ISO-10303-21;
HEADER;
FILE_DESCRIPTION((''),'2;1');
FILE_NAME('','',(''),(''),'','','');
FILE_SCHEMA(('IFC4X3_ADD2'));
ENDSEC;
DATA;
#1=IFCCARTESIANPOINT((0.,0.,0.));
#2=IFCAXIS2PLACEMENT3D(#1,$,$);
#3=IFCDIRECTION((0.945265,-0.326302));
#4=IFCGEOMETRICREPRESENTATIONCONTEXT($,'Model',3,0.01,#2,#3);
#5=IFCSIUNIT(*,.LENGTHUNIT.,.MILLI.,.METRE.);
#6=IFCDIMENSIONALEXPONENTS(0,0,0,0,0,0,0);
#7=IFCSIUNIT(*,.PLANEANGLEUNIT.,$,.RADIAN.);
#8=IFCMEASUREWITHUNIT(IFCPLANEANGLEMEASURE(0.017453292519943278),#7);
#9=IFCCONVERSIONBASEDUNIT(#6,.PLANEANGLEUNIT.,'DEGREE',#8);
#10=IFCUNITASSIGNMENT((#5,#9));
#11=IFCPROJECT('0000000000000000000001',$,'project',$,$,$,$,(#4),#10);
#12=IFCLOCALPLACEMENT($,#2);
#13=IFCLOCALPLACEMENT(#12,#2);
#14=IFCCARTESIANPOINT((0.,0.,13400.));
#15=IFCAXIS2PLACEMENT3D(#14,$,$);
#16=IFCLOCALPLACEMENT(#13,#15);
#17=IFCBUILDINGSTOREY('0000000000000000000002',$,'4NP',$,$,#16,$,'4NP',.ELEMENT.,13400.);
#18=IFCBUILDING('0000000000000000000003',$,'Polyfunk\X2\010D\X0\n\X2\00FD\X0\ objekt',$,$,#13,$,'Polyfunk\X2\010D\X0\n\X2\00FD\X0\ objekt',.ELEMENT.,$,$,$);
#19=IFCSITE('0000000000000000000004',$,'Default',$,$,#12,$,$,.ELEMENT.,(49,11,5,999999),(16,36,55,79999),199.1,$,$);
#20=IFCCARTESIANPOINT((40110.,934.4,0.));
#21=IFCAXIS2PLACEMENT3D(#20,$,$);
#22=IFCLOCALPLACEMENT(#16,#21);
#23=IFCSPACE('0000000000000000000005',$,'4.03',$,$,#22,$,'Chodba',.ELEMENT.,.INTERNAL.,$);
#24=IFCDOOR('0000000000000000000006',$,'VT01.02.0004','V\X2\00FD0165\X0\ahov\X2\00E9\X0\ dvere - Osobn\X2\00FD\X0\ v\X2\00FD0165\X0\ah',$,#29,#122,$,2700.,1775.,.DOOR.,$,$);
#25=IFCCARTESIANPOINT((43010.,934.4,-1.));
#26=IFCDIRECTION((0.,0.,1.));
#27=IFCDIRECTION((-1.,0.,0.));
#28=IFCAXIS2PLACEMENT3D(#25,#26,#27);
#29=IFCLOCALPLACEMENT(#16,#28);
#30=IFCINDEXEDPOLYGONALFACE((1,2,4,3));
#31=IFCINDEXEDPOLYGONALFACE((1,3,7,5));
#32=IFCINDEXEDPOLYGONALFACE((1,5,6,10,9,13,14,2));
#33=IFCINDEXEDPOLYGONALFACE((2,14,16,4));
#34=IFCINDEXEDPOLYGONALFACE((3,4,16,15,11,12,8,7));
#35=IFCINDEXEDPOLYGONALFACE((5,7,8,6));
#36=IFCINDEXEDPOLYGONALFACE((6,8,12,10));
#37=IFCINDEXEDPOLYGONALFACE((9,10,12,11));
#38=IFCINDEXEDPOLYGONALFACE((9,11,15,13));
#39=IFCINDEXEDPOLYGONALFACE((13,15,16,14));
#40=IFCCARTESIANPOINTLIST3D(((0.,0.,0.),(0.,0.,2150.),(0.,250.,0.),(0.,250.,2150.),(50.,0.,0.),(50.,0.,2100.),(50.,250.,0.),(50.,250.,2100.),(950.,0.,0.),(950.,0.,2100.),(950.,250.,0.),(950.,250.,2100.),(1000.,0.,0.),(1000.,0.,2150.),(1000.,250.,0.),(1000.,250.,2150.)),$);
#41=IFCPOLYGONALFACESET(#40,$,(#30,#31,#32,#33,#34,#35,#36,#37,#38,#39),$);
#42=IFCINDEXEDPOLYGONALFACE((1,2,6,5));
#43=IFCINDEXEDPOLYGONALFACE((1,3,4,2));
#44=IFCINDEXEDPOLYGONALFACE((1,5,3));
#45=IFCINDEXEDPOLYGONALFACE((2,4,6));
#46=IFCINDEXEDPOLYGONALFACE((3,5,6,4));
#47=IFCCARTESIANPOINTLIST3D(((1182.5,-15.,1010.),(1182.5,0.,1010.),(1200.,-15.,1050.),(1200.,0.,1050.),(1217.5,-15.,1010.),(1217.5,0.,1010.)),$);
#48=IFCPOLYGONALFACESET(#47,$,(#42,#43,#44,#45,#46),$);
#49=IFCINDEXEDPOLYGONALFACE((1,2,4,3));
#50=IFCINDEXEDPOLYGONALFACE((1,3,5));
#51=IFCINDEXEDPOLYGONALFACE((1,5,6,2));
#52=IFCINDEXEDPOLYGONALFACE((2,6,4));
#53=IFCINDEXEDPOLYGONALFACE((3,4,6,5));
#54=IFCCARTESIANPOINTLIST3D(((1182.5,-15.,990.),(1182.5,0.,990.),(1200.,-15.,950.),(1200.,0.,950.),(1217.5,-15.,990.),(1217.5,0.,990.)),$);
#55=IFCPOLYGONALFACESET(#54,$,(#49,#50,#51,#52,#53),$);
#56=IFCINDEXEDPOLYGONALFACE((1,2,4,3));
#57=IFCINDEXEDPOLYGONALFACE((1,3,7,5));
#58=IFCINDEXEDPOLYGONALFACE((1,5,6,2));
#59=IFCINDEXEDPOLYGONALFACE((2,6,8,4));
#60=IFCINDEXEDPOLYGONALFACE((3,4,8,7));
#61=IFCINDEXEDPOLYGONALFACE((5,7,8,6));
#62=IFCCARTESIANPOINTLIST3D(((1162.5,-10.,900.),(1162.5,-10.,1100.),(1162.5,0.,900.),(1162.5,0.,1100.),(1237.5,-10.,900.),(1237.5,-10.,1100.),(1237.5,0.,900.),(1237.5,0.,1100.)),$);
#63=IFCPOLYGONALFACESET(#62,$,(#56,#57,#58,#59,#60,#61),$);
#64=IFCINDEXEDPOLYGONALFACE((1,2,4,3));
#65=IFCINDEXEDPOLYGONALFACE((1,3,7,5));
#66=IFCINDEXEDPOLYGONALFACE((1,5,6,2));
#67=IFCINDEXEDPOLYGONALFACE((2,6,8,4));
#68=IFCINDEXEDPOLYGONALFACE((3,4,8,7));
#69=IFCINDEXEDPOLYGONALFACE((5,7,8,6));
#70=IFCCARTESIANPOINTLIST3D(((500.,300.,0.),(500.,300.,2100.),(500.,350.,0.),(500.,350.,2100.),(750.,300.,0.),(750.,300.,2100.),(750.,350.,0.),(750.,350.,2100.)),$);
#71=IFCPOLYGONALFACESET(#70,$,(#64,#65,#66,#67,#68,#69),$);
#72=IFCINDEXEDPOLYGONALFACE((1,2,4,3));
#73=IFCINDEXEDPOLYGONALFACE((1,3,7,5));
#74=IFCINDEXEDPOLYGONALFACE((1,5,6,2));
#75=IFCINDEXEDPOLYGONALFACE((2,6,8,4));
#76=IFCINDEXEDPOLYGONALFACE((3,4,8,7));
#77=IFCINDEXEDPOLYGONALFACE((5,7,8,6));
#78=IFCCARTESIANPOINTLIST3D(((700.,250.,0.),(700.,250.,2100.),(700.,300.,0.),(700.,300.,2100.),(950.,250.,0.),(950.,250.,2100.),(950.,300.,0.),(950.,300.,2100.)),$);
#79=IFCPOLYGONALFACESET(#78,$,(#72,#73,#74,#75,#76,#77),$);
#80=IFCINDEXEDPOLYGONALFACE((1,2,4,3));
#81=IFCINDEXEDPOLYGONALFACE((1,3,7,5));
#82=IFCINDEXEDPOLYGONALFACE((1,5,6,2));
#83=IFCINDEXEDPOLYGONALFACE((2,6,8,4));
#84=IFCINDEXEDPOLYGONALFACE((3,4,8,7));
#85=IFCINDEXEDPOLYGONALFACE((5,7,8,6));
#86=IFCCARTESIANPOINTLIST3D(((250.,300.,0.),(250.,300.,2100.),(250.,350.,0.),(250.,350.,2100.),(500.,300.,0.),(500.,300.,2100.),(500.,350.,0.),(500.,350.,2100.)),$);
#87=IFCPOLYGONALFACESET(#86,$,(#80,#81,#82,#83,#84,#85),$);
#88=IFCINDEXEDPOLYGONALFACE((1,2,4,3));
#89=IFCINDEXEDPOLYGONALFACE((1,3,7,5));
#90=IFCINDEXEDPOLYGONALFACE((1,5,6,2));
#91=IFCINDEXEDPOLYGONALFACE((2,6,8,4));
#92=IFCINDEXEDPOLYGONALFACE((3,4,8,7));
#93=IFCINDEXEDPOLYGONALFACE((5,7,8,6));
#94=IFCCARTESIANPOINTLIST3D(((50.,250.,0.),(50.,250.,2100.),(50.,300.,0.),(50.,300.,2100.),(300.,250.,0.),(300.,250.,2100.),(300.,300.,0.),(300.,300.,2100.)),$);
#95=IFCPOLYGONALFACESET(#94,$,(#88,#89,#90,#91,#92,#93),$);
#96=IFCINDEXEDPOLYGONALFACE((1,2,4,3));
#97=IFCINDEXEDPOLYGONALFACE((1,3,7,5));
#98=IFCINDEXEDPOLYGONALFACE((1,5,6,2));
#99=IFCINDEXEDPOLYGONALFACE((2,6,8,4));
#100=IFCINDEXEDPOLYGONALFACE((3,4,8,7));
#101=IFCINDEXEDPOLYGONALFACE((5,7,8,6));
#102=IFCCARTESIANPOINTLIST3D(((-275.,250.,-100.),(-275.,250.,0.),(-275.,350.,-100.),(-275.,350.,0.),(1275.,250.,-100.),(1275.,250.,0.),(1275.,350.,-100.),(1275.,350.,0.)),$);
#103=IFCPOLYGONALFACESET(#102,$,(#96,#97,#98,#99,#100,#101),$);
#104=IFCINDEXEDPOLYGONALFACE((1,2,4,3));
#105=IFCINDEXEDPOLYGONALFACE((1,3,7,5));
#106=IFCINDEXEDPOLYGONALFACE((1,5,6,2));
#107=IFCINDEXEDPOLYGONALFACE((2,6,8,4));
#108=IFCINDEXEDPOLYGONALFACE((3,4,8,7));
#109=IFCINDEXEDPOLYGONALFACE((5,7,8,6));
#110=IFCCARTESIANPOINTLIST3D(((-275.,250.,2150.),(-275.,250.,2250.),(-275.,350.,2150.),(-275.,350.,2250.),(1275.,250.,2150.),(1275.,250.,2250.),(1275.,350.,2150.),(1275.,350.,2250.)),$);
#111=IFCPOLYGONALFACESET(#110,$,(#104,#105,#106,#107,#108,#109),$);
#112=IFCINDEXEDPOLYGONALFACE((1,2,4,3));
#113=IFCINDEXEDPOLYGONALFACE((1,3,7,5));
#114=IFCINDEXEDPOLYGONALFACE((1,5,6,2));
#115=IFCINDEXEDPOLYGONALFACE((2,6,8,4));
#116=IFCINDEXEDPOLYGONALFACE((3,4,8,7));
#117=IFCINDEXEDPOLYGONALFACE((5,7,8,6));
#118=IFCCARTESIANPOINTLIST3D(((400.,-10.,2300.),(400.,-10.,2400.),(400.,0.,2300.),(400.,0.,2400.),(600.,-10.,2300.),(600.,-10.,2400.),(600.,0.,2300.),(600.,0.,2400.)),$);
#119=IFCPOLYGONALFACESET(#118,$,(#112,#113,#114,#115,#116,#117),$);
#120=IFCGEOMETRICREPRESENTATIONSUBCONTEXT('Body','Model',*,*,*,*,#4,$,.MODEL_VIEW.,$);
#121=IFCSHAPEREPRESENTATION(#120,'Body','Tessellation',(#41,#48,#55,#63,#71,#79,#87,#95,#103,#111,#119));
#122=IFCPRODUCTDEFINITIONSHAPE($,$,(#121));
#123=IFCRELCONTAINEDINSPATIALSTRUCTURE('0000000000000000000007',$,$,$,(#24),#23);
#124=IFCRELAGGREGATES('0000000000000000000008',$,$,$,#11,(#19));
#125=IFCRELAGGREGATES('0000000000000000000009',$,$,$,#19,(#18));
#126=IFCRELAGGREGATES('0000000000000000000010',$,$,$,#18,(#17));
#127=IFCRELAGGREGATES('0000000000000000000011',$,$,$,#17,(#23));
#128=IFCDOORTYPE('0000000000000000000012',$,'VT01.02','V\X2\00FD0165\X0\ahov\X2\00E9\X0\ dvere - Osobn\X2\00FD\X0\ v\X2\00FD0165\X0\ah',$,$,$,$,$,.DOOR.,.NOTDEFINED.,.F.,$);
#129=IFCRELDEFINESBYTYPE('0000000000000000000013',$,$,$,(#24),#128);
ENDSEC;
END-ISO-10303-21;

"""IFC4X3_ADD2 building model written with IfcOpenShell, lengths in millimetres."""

from ifc_helpers import new_model, entity, si_unit, converted_unit, direction, frame, frame_2d, origin, origin_2d_with_axis, place, context, subcontext, project, spatial, polyline, rectangle, outline, extrude, source, transform, mapped, type_object, type_shapes, element, save


model = new_model("IFC4X3_ADD2")

# Units and contexts
model_context = context("Model", 3, precision=0.01, world=origin(), true_north=direction((0.945265, -0.326302)))
body_context = subcontext(model_context, "Body", "Model", "MODEL_VIEW")
ifc_project = project(units=[si_unit("LENGTHUNIT", "METRE", prefix="MILLI"), converted_unit("PLANEANGLEUNIT", "DEGREE", entity("IfcPlaneAngleMeasure", 0.017453292519943278), si_unit("PLANEANGLEUNIT", "RADIAN"), dimensions=[0, 0, 0, 0, 0, 0, 0])], contexts=[model_context])

# Site, building, storey
site_placement = place(None, origin())
site = spatial("IfcSite", under=ifc_project, at=site_placement, Name="Default", CompositionType="ELEMENT", RefLatitude=(49, 11, 5, 999999), RefLongitude=(16, 36, 55, 79999), RefElevation=199.1)
building_placement = place(site_placement, origin())
building = spatial("IfcBuilding", under=site, at=building_placement, Name="Polyfunkčný objekt", LongName="Polyfunkčný objekt", CompositionType="ELEMENT")
storey_placement = place(building_placement, frame((0.0, 0.0, 13400.0)))
storey = spatial("IfcBuildingStorey", under=building, at=storey_placement, Name="4NP", LongName="4NP", CompositionType="ELEMENT", Elevation=13400.0)

# Shared definitions
space_placement = place(storey_placement, frame((40110.0, 934.4, 0.0)))
space = spatial("IfcSpace", under=storey, at=space_placement, Name="4.03", LongName="Chodba", CompositionType="ELEMENT", PredefinedType="INTERNAL")

# Door
door_type_1 = type_object("IfcDoorType", Name="VT01.02", Description="Výťahové dvere - Osobný výťah", OperationType="NOTDEFINED", ParameterTakesPrecedence=False, PredefinedType="DOOR")
shared_shape_1 = source(origin(), body_context, "Body", "SweptSolid", [
    extrude(outline(polyline([(-1087.5, -500.0), (1062.5, -500.0), (1062.5, -450.0), (-1037.5, -450.0), (-1037.5, 450.0), (1062.5, 450.0), (1062.5, 500.0), (-1087.5, 500.0), (-1087.5, -500.0)])), frame((500.0, 0.0, 1062.5), z_axis=(0.0, 1.0, 0.0), x_axis=(0.0, 0.0, -1.0)), (0.0, 0.0, 1.0), 250.0),
    extrude(outline(polyline([(-24.4, -10.7), (19.2, -10.7), (5.2, 21.4), (-24.4, -10.7)])), frame((1200.0, -15.0, 1023.3), z_axis=(0.0, 1.0, 0.0), x_axis=(0.400819, 0.0, -0.916157)), (0.0, 0.0, 1.0), 15.0),
    extrude(outline(polyline([(-24.4, -10.7), (19.2, -10.7), (5.2, 21.4), (-24.4, -10.7)])), frame((1200.0, -15.0, 976.7), z_axis=(0.0, 1.0, 0.0), x_axis=(-0.400819, 0.0, 0.916157)), (0.0, 0.0, 1.0), 15.0),
    extrude(rectangle(XDim=10.0, YDim=75.0, at=frame_2d((0.0, 0.0), x_axis=(1.0, 0.0))), frame((1200.0, -5.0, 900.0), z_axis=(0.0, 0.0, 1.0), x_axis=(0.0, 1.0, 0.0)), (0.0, 0.0, 1.0), 200.0),
    extrude(rectangle(XDim=50.0, YDim=250.0, at=origin_2d_with_axis()), frame((625.0, 325.0, 0.0), z_axis=(0.0, 0.0, 1.0), x_axis=(0.0, -1.0, 0.0)), (0.0, 0.0, 1.0), 2100.0),
    extrude(rectangle(XDim=50.0, YDim=250.0, at=frame_2d((0.0, 0.0), x_axis=(1.0, 0.0))), frame((825.0, 275.0, 0.0), z_axis=(0.0, 0.0, 1.0), x_axis=(0.0, -1.0, 0.0)), (0.0, 0.0, 1.0), 2100.0),
    extrude(rectangle(XDim=250.0, YDim=50.0, at=frame_2d((0.0, 0.0), x_axis=(1.0, 0.0))), frame((375.0, 325.0, 0.0), z_axis=(0.0, 0.0, 1.0), x_axis=(-1.0, 0.0, 0.0)), (0.0, 0.0, 1.0), 2100.0),
    extrude(rectangle(XDim=250.0, YDim=50.0, at=frame_2d((0.0, 0.0), x_axis=(1.0, 0.0))), frame((175.0, 275.0, 0.0), z_axis=(0.0, 0.0, 1.0), x_axis=(-1.0, 0.0, 0.0)), (0.0, 0.0, 1.0), 2100.0),
    extrude(rectangle(XDim=1550.0, YDim=100.0, at=frame_2d((0.0, 0.0), x_axis=(1.0, 0.0))), frame((500.0, 300.0, -100.0), z_axis=(0.0, 0.0, 1.0), x_axis=(-1.0, 0.0, 0.0)), (0.0, 0.0, 1.0), 100.0),
    extrude(rectangle(XDim=1550.0, YDim=100.0, at=frame_2d((0.0, 0.0), x_axis=(1.0, 0.0))), frame((500.0, 300.0, 2150.0), z_axis=(0.0, 0.0, 1.0), x_axis=(-1.0, 0.0, 0.0)), (0.0, 0.0, 1.0), 100.0),
    extrude(rectangle(XDim=10.0, YDim=200.0, at=frame_2d((0.0, 0.0), x_axis=(1.0, 0.0))), frame((500.0, -5.0, 2300.0), z_axis=(0.0, 0.0, 1.0), x_axis=(0.0, 1.0, 0.0)), (0.0, 0.0, 1.0), 100.0),
])
type_shapes(door_type_1, [shared_shape_1])
door_1_placement = place(storey_placement, frame((43010.0, 934.4, -1.0), z_axis=(0.0, 0.0, 1.0), x_axis=(-1.0, 0.0, 0.0)))
element("IfcDoor", 1, at=door_1_placement, inside=space, type_object=door_type_1, Name="VT01.02.0004", Description="Výťahové dvere - Osobný výťah", OverallHeight=2700.0, OverallWidth=1775.0, PredefinedType="DOOR", context=body_context, shape_type="MappedRepresentation", body=[
    mapped(shared_shape_1, transform((0.0, 0.0, 0.0), scale=1.0)),
])

save(model, "model.ifc")
